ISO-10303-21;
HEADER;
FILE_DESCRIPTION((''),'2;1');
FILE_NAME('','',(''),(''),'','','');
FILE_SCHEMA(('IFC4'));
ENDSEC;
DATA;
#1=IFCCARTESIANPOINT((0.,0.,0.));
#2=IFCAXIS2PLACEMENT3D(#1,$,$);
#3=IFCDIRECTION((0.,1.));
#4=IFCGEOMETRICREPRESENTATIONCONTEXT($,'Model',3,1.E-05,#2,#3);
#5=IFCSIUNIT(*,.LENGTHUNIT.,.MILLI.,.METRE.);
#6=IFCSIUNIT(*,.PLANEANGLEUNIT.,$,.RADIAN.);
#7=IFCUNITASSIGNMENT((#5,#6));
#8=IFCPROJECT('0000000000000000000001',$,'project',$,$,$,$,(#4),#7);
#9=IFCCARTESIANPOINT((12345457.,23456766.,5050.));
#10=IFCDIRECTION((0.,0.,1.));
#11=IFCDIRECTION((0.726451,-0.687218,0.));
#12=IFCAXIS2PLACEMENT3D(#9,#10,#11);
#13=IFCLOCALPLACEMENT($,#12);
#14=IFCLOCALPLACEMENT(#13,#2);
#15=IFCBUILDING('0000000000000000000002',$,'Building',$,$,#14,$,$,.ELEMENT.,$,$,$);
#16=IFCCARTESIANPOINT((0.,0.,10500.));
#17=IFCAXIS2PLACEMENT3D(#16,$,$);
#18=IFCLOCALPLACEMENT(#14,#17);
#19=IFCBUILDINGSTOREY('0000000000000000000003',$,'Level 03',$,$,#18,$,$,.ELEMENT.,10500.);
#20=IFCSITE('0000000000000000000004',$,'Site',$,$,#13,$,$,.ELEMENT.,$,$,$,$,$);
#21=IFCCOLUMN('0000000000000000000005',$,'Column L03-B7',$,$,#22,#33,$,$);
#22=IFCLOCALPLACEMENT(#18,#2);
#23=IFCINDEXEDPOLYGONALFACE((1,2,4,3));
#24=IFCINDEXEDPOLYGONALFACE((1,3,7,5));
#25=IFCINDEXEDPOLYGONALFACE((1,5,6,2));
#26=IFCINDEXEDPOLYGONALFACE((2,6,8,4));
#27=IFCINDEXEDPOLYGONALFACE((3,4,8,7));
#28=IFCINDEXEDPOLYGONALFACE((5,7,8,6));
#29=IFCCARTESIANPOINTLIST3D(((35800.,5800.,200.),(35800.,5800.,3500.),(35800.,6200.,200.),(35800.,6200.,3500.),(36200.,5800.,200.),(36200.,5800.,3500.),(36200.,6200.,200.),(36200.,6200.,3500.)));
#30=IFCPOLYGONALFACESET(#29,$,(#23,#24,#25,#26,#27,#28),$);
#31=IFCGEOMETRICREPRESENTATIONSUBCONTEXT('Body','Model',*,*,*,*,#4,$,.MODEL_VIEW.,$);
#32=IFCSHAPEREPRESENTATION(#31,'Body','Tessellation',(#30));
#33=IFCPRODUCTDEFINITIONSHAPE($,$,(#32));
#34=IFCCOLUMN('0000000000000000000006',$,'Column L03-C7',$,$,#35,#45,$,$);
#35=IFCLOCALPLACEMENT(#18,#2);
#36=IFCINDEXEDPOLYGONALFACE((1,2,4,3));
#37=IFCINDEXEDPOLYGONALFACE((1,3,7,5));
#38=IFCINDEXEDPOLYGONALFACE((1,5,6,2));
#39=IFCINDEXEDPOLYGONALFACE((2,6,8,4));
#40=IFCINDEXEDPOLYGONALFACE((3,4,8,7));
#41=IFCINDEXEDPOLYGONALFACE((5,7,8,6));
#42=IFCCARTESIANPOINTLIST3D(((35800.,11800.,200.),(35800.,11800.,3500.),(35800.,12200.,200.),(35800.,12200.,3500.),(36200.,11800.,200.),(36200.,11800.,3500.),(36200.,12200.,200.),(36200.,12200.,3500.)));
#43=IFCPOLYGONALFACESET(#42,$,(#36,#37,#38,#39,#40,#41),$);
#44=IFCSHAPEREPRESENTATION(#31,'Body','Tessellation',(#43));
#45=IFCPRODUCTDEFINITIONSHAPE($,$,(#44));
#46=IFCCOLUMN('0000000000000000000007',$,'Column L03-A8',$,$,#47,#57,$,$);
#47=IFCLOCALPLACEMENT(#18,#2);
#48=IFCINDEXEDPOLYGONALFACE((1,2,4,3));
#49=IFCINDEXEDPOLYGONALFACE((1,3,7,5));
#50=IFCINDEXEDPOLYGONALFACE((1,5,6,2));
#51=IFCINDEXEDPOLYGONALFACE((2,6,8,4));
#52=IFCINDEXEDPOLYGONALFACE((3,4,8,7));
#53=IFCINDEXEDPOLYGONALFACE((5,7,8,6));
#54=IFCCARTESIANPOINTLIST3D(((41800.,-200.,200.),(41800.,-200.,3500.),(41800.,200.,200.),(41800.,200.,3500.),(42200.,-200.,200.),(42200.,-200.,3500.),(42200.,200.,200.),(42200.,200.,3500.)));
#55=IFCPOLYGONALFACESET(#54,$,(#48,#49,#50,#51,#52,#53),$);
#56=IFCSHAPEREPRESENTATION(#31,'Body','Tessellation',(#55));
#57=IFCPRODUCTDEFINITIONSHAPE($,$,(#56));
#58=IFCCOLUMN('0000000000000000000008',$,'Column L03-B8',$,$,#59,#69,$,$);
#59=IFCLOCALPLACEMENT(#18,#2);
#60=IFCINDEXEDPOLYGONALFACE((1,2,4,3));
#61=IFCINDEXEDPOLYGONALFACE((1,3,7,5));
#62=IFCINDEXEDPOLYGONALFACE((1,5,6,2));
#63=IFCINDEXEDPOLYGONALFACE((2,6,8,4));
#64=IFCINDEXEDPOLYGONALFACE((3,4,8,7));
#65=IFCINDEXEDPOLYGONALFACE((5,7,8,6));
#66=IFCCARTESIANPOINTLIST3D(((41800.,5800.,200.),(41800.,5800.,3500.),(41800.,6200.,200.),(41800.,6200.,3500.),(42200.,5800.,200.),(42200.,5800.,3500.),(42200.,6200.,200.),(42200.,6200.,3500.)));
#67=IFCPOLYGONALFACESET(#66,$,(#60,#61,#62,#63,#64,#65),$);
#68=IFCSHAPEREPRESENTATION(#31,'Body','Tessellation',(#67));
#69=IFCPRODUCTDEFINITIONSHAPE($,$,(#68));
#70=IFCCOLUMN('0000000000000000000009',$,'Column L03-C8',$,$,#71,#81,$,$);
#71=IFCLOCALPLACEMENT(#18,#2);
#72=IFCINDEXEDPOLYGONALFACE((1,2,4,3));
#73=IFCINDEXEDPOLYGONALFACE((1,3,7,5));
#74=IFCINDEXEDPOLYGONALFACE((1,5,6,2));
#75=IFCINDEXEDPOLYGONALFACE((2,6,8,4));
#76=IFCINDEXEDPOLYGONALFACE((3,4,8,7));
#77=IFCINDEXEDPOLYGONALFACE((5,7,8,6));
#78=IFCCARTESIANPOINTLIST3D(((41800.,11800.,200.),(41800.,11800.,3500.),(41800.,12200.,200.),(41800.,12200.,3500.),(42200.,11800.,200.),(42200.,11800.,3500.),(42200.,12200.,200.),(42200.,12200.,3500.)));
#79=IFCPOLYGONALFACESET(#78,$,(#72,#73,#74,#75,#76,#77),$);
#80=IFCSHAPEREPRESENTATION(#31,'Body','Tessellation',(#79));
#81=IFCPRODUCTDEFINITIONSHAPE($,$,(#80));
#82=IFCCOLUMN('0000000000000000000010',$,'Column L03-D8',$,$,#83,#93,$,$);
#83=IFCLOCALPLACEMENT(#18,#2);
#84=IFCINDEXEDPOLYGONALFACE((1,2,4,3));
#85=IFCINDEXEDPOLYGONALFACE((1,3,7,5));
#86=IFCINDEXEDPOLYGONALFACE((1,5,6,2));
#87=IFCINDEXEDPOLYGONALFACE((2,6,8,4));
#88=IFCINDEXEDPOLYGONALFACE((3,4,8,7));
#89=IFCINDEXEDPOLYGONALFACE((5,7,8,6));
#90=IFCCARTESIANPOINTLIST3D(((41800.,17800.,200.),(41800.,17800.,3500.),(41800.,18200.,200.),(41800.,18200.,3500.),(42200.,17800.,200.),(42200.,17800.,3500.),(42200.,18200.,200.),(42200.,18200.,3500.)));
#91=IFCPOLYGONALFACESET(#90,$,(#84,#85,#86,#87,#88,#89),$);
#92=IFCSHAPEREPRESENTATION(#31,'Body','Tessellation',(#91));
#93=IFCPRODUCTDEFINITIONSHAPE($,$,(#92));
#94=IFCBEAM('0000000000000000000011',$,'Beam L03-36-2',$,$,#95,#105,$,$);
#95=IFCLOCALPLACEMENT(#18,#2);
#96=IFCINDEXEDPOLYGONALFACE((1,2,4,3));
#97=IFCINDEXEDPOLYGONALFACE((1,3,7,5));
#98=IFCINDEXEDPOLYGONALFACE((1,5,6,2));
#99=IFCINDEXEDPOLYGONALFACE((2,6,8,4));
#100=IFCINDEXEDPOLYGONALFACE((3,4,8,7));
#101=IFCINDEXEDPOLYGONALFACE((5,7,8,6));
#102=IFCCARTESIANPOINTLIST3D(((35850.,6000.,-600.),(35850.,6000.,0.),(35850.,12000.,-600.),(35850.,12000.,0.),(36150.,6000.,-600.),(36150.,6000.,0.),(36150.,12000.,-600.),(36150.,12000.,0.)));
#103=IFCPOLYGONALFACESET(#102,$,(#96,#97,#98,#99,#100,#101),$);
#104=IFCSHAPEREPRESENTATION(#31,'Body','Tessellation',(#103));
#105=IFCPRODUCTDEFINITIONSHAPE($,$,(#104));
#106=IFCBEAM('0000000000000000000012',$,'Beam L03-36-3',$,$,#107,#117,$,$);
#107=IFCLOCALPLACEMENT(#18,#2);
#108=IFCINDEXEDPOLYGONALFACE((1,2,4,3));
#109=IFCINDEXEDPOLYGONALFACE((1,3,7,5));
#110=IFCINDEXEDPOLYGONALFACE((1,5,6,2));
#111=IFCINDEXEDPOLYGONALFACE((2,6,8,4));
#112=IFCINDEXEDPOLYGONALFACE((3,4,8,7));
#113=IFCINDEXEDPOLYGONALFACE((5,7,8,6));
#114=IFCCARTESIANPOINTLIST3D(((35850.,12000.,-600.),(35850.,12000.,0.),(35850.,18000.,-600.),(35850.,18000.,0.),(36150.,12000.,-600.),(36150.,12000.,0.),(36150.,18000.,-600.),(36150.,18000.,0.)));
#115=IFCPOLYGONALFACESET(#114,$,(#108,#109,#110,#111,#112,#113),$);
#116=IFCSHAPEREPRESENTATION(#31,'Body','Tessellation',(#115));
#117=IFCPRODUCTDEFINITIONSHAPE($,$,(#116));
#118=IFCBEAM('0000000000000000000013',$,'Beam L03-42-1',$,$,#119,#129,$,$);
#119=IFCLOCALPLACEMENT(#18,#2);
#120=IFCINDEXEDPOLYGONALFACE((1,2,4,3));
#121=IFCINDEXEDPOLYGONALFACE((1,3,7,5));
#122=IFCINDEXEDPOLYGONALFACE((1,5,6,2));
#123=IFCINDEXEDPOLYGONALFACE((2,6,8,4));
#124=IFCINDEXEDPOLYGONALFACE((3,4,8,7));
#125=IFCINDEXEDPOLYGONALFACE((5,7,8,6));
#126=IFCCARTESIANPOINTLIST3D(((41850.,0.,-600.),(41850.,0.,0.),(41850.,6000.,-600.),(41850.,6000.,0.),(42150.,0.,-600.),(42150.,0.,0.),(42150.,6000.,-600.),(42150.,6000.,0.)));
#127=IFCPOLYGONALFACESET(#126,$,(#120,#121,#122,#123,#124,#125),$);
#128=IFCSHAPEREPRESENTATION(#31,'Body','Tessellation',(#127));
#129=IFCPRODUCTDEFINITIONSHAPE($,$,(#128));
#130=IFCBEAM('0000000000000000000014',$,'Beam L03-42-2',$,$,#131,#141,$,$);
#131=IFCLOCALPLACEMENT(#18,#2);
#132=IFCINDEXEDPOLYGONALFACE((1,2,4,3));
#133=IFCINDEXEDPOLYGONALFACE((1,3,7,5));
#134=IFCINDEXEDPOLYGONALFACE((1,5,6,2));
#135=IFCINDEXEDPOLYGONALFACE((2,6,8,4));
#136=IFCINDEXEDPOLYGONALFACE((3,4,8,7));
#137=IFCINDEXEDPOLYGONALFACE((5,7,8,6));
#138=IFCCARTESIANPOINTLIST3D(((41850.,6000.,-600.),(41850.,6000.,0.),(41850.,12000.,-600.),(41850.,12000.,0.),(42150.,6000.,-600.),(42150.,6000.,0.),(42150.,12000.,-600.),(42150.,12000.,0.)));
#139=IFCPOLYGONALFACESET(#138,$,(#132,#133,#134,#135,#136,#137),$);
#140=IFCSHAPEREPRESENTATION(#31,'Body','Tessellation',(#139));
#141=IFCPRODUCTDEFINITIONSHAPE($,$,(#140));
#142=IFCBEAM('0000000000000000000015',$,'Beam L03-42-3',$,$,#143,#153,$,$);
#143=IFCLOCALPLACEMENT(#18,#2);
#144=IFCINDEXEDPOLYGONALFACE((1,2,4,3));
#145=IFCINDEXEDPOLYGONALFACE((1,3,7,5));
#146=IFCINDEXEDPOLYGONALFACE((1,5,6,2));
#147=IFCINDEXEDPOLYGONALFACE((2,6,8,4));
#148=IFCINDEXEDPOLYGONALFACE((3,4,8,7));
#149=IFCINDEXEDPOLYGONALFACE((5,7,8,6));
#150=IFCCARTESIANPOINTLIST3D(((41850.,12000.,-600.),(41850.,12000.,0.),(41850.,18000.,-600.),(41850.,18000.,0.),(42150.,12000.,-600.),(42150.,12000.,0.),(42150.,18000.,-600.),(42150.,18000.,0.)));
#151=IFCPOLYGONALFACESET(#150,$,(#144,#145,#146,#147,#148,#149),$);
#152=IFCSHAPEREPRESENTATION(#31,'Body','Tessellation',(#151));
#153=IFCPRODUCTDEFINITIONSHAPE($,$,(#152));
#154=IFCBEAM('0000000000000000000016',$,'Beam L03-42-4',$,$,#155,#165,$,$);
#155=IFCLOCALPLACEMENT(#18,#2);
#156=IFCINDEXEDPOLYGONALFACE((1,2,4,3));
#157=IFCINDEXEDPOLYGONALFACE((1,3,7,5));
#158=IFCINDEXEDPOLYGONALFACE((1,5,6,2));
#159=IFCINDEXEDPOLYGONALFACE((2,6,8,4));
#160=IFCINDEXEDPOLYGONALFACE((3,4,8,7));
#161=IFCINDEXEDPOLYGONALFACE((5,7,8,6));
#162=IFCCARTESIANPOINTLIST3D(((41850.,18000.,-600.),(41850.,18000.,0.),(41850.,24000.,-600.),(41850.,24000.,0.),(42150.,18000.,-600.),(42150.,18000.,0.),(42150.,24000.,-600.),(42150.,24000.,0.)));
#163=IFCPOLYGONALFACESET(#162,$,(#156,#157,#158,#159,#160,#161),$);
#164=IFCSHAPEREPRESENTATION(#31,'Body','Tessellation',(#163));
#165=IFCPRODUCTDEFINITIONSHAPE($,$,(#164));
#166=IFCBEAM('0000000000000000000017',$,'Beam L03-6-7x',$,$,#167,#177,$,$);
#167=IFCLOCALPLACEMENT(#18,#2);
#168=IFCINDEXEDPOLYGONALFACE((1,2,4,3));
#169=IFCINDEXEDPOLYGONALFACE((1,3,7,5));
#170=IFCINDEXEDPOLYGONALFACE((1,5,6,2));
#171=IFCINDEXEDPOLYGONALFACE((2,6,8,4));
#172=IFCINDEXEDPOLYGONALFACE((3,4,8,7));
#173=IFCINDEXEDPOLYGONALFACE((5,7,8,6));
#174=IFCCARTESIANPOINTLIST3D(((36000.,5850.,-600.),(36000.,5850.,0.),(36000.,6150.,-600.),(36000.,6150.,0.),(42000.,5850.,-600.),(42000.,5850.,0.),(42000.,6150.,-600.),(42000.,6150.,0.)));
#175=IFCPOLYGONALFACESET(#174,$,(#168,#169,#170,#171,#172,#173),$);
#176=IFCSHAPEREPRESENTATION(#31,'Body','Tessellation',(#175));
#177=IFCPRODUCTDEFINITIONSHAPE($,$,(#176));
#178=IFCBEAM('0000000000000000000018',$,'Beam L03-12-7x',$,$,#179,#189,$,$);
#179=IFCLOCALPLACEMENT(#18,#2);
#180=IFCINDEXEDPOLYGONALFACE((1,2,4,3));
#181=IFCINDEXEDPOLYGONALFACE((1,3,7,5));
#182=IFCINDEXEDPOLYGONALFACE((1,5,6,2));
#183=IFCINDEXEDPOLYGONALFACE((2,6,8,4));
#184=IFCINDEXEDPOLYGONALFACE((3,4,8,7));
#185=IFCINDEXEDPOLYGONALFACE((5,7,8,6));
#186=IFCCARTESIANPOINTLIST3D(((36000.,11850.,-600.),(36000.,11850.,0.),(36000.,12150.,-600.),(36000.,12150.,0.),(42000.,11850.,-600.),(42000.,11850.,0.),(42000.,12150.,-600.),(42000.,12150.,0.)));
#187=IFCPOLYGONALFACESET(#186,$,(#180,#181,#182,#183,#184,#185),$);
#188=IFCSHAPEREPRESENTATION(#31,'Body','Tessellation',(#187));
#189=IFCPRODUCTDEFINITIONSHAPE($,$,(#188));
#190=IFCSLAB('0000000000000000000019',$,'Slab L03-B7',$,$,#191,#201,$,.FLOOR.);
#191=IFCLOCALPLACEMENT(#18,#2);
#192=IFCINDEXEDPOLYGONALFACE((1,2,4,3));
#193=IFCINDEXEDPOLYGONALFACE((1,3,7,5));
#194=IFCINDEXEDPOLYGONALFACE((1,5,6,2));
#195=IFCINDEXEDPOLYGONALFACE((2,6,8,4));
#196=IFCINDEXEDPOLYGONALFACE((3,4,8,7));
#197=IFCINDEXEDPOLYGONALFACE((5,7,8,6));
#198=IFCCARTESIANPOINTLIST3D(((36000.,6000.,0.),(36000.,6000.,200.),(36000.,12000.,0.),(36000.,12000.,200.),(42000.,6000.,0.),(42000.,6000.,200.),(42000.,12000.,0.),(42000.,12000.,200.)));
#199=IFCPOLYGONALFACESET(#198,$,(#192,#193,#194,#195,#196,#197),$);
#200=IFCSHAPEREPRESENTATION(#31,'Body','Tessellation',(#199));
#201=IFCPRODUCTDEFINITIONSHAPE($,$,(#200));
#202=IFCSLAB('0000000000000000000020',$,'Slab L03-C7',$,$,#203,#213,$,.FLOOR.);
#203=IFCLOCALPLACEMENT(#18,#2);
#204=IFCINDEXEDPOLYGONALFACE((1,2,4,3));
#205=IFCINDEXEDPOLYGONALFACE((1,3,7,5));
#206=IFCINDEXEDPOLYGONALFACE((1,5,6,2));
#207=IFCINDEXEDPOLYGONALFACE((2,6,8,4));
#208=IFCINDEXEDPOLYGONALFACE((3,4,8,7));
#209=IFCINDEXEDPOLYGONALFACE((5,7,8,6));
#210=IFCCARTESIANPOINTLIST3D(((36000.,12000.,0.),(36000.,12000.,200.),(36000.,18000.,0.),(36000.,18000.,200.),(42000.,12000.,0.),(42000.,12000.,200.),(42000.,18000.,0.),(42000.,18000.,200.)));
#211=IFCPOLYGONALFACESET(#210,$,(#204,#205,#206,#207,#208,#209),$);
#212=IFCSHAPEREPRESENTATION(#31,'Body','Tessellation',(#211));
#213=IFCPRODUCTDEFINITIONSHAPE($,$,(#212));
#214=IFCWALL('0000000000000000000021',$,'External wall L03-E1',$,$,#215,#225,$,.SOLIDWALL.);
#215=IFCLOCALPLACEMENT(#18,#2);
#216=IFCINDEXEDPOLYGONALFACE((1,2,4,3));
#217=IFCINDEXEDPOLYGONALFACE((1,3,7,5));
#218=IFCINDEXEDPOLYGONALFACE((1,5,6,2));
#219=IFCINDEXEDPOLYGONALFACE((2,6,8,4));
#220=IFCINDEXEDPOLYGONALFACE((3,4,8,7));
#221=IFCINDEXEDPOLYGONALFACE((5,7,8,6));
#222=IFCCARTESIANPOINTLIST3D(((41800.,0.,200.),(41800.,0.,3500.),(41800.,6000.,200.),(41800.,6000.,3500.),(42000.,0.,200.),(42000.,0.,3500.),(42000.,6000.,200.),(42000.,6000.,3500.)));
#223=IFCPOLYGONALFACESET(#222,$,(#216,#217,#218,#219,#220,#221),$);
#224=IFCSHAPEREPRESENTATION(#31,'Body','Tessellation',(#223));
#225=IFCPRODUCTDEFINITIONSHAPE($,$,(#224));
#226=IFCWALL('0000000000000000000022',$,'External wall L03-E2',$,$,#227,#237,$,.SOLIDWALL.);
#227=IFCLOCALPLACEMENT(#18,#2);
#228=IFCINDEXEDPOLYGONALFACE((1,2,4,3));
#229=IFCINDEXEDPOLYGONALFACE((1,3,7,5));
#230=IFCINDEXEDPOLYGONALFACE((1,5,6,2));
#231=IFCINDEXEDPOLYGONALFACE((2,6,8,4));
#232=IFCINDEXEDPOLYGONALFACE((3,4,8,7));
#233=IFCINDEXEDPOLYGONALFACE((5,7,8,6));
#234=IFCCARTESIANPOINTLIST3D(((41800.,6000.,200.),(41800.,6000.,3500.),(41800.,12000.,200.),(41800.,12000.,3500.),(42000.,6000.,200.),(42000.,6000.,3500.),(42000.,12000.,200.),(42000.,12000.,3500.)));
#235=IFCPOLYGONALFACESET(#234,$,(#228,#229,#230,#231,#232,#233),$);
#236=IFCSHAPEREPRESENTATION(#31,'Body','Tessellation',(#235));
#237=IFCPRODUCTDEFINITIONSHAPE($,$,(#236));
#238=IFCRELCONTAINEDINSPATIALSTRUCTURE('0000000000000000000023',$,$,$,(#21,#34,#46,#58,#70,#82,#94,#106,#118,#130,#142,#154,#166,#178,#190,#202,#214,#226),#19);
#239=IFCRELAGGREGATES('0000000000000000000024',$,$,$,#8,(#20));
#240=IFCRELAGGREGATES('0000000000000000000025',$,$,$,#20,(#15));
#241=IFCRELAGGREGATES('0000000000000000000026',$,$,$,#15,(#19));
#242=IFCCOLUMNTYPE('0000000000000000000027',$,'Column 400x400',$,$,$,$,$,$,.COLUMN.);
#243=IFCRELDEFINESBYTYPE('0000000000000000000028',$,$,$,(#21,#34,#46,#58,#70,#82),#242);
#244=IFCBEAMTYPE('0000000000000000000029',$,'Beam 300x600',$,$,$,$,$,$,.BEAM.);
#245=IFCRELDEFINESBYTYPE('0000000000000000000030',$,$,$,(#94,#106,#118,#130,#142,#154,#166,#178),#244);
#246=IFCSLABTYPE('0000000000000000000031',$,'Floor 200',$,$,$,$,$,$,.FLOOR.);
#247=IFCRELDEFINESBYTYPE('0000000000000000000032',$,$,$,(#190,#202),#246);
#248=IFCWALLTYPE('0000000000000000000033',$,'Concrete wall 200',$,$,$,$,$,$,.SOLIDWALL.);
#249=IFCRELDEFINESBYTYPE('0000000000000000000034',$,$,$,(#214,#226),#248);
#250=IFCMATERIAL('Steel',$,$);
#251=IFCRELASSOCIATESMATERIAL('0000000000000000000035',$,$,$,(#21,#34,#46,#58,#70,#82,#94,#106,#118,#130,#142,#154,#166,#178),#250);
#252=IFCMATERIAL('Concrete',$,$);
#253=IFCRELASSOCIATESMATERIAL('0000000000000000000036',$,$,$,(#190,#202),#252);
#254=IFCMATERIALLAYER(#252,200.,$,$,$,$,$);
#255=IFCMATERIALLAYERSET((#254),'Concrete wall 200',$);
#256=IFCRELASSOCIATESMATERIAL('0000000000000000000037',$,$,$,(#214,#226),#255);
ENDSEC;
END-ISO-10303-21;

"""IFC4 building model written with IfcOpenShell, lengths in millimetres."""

from ifc_helpers import new_model, si_unit, direction, frame, origin, place, context, subcontext, project, spatial, rectangle, extrude, material, layer, layer_set, layer_usage, type_object, element, save


model = new_model("IFC4")

# Units and contexts
model_context = context("Model", 3, precision=1e-05, world=origin(), true_north=direction((0.0, 1.0)))
body_context = subcontext(model_context, "Body", "Model", "MODEL_VIEW")
ifc_project = project(units=[si_unit("LENGTHUNIT", "METRE", prefix="MILLI"), si_unit("PLANEANGLEUNIT", "RADIAN")], contexts=[model_context])

# Site, building, storey
site_placement = place(None, frame((12345457.0, 23456766.0, 5050.0), z_axis=(0.0, 0.0, 1.0), x_axis=(0.726451, -0.687218, 0.0)))
site = spatial("IfcSite", under=ifc_project, at=site_placement, Name="Site", CompositionType="ELEMENT")
building_placement = place(site_placement, origin())
building = spatial("IfcBuilding", under=site, at=building_placement, Name="Building", CompositionType="ELEMENT")
storey_placement = place(building_placement, frame((0.0, 0.0, 10500.0)))
storey = spatial("IfcBuildingStorey", under=building, at=storey_placement, Name="Level 03", CompositionType="ELEMENT", Elevation=10500.0)

# Columns
ifc_material_1 = material(Name="Steel")
column_type = type_object("IfcColumnType", Name="Column 400x400", PredefinedType="COLUMN")
for number, where, name in (
    (1, (35800.0, 5800.0, 200.0), "Column L03-B7"),
    (2, (35800.0, 11800.0, 200.0), "Column L03-C7"),
    (3, (41800.0, -200.0, 200.0), "Column L03-A8"),
    (4, (41800.0, 5800.0, 200.0), "Column L03-B8"),
    (5, (41800.0, 11800.0, 200.0), "Column L03-C8"),
    (6, (41800.0, 17800.0, 200.0), "Column L03-D8"),
):
    element("IfcColumn", number, at=place(storey_placement, frame(where)), inside=storey, type_object=column_type, material=ifc_material_1, Name=name, context=body_context, shape_type="SweptSolid", body=[
        extrude(rectangle(XDim=400.0, YDim=400.0), frame((200.0, 200.0, 0.0)), (0.0, 0.0, 1.0), 3300.0),
    ])

# Beams
beam_type = type_object("IfcBeamType", Name="Beam 300x600", PredefinedType="BEAM")
for number, where, name in (
    (7, (35850.0, 6000.0, -600.0), "Beam L03-36-2"),
    (8, (35850.0, 12000.0, -600.0), "Beam L03-36-3"),
    (9, (41850.0, 0.0, -600.0), "Beam L03-42-1"),
    (10, (41850.0, 6000.0, -600.0), "Beam L03-42-2"),
    (11, (41850.0, 12000.0, -600.0), "Beam L03-42-3"),
    (12, (41850.0, 18000.0, -600.0), "Beam L03-42-4"),
):
    element("IfcBeam", number, at=place(storey_placement, frame(where)), inside=storey, type_object=beam_type, material=ifc_material_1, Name=name, context=body_context, shape_type="SweptSolid", body=[
        extrude(rectangle(XDim=300.0, YDim=6000.0), frame((150.0, 3000.0, 0.0)), (0.0, 0.0, 1.0), 600.0),
    ])
for number, where, name in (
    (13, (36000.0, 5850.0, -600.0), "Beam L03-6-7x"),
    (14, (36000.0, 11850.0, -600.0), "Beam L03-12-7x"),
):
    element("IfcBeam", number, at=place(storey_placement, frame(where)), inside=storey, type_object=beam_type, material=ifc_material_1, Name=name, context=body_context, shape_type="SweptSolid", body=[
        extrude(rectangle(XDim=6000.0, YDim=300.0), frame((3000.0, 150.0, 0.0)), (0.0, 0.0, 1.0), 600.0),
    ])

# Slabs
ifc_material_2 = material(Name="Concrete")
slab_type = type_object("IfcSlabType", Name="Floor 200", PredefinedType="FLOOR")
for number, where, name in (
    (15, (36000.0, 6000.0, 0.0), "Slab L03-B7"),
    (16, (36000.0, 12000.0, 0.0), "Slab L03-C7"),
):
    element("IfcSlab", number, at=place(storey_placement, frame(where)), inside=storey, type_object=slab_type, material=ifc_material_2, Name=name, PredefinedType="FLOOR", context=body_context, shape_type="SweptSolid", body=[
        extrude(rectangle(XDim=6000.0, YDim=6000.0), frame((3000.0, 3000.0, 0.0)), (0.0, 0.0, 1.0), 200.0),
    ])

# Walls
ifc_layer_1 = layer(ifc_material_2, 200.0)
ifc_layer_set_1 = layer_set([ifc_layer_1], Name="Concrete wall 200")
ifc_layer_usage_1 = layer_usage(ifc_layer_set_1, "AXIS2", "POSITIVE", 0.0)
wall_type_1 = type_object("IfcWallType", Name="Concrete wall 200", PredefinedType="SOLIDWALL")
for number, where, name in (
    (17, (41800.0, 0.0, 200.0), "External wall L03-E1"),
    (18, (41800.0, 6000.0, 200.0), "External wall L03-E2"),
):
    element("IfcWall", number, at=place(storey_placement, frame(where)), inside=storey, type_object=wall_type_1, material=ifc_layer_usage_1, Name=name, PredefinedType="SOLIDWALL", context=body_context, shape_type="SweptSolid", body=[
        extrude(rectangle(XDim=200.0, YDim=6000.0), frame((100.0, 3000.0, 0.0)), (0.0, 0.0, 1.0), 3300.0),
    ])

save(model, "model.ifc")
